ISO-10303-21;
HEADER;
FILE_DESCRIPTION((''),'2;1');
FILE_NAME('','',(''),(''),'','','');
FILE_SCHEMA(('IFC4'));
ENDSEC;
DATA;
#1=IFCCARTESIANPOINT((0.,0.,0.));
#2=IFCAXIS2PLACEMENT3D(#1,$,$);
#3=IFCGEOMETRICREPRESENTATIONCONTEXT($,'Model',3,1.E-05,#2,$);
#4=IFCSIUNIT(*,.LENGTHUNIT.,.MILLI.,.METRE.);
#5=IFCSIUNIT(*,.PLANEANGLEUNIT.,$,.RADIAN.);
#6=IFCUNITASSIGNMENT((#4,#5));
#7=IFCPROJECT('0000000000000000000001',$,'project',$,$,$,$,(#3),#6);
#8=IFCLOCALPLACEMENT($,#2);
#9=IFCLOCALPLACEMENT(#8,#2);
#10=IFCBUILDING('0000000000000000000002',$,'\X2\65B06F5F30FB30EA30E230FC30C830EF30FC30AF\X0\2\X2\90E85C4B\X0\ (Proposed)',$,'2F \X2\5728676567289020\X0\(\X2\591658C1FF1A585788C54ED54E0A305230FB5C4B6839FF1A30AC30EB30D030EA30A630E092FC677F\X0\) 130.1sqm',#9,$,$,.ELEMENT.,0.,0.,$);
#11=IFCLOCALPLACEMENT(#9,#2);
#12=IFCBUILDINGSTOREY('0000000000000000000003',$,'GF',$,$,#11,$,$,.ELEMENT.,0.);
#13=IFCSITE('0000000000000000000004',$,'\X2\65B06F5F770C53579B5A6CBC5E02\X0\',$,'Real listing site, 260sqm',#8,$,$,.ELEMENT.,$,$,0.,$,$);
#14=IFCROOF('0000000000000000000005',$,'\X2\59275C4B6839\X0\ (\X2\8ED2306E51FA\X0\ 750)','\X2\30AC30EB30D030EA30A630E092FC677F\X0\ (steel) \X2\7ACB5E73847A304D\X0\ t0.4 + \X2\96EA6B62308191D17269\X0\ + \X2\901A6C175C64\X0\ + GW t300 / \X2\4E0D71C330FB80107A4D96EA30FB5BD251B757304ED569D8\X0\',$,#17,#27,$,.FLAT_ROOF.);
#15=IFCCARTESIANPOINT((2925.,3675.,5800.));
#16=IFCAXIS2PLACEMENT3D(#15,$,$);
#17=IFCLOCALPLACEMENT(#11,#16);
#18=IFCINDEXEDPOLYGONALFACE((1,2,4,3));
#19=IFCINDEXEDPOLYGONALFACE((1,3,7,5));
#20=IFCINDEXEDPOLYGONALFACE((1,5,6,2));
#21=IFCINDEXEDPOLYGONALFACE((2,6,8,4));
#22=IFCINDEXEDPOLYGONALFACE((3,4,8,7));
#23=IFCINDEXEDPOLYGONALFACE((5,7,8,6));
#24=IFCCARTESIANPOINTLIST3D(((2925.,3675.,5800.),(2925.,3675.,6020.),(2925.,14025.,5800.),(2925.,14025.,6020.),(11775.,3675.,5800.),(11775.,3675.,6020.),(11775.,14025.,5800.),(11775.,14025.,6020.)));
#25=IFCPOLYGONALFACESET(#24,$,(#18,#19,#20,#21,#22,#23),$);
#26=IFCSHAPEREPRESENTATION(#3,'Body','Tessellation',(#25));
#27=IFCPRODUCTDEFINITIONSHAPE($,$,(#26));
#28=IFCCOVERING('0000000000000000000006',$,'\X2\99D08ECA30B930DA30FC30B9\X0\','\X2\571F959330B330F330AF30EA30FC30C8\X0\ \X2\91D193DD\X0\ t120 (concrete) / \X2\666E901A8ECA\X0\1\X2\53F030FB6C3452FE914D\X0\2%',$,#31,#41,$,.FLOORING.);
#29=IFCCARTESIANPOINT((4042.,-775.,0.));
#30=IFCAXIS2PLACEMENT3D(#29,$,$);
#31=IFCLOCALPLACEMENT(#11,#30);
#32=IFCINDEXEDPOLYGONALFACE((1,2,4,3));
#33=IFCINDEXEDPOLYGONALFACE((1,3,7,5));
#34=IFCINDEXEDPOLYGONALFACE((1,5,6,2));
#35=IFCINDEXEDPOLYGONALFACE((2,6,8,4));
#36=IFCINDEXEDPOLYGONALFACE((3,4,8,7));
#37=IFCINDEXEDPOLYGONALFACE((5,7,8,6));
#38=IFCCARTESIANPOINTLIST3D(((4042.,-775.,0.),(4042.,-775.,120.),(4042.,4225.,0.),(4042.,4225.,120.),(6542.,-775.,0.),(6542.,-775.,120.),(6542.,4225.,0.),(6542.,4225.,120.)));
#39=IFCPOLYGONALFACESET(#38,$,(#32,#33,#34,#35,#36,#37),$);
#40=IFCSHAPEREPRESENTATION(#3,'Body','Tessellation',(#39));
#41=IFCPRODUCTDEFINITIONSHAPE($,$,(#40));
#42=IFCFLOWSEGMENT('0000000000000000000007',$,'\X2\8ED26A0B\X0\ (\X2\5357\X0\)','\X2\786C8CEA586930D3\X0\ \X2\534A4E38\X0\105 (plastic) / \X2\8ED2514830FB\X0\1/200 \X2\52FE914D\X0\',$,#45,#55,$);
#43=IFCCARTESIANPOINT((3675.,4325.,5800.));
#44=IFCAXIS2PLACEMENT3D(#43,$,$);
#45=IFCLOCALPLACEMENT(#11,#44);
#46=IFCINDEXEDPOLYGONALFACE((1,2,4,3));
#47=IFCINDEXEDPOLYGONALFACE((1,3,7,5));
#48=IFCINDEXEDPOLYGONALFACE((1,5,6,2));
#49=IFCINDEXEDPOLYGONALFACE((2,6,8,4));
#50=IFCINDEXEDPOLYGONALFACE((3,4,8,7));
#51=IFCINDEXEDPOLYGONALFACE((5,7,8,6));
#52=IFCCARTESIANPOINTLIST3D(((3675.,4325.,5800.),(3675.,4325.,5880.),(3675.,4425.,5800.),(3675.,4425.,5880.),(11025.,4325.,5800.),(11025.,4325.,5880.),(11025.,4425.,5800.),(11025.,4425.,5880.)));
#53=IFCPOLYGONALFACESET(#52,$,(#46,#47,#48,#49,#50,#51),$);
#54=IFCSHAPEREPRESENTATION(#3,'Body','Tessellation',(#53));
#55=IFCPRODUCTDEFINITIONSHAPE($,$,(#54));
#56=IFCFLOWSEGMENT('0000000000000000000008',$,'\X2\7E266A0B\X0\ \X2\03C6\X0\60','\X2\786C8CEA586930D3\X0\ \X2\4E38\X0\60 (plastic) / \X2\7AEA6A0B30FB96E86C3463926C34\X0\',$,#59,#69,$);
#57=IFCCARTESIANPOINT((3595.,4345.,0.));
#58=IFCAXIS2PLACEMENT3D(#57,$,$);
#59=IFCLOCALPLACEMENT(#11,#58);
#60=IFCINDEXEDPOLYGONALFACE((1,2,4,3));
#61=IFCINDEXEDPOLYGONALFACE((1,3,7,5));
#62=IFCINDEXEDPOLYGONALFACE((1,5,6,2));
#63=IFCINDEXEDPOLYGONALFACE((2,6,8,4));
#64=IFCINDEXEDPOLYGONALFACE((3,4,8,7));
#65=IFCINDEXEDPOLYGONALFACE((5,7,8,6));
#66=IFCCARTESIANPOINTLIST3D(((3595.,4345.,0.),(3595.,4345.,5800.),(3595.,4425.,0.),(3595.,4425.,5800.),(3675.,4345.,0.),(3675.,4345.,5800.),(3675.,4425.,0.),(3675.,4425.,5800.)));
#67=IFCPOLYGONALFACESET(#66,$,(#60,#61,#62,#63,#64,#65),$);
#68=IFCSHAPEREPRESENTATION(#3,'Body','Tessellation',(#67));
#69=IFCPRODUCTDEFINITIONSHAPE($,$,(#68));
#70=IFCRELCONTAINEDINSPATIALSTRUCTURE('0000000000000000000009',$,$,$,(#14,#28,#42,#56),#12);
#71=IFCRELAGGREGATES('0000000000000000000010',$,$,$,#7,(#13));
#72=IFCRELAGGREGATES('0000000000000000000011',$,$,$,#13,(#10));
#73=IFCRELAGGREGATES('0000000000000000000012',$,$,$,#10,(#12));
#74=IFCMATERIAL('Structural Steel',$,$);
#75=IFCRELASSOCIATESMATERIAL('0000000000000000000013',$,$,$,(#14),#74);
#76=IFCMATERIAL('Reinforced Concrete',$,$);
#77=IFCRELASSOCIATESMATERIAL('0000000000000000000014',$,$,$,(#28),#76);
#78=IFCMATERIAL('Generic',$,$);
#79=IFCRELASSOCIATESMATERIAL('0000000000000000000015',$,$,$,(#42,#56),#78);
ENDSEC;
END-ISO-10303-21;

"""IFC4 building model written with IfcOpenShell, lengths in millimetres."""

from ifc_helpers import new_model, si_unit, frame, frame_2d, origin, place, context, project, spatial, rectangle, extrude, material, element, save


model = new_model("IFC4")

# Units and contexts
model_context = context("Model", 3, precision=1e-05, world=origin())
ifc_project = project(units=[si_unit("LENGTHUNIT", "METRE", prefix="MILLI"), si_unit("PLANEANGLEUNIT", "RADIAN")], contexts=[model_context])

# Site, building, storey
site_placement = place(None, origin())
site = spatial("IfcSite", under=ifc_project, at=site_placement, Name="新潟県南魚沼市", ObjectType="Real listing site, 260sqm", CompositionType="ELEMENT", RefElevation=0.0)
building_placement = place(site_placement, origin())
building = spatial("IfcBuilding", under=site, at=building_placement, Name="新潟・リモートワーク2部屋 (Proposed)", ObjectType="2F 在来木造(外壁：塗装仕上げ・屋根：ガルバリウム鋼板) 130.1sqm", CompositionType="ELEMENT", ElevationOfRefHeight=0.0, ElevationOfTerrain=0.0)
storey_placement = place(building_placement, origin())
storey = spatial("IfcBuildingStorey", under=building, at=storey_placement, Name="GF", CompositionType="ELEMENT", Elevation=0.0)

# Shared definitions
ifc_material_1 = material(Name="Reinforced Concrete")

# Roof
ifc_material_2 = material(Name="Structural Steel")
roof_placement = place(storey_placement, frame((2925.0, 3675.0, 5800.0)))
element("IfcRoof", 1, at=roof_placement, inside=storey, material=ifc_material_2, Name="大屋根 (軒の出 750)", Description="ガルバリウム鋼板 (steel) 立平葺き t0.4 + 雪止め金物 + 通気層 + GW t300 / 不燃・耐積雪・寒冷地仕様", PredefinedType="FLAT_ROOF", context=model_context, shape_type="SweptSolid", body=[
    extrude(rectangle(XDim=8850.0, YDim=10350.0, at=frame_2d((4425.0, 5175.0))), frame((2925.0, 3675.0, 5800.0)), (0.0, 0.0, 1.0), 220.0),
])

# Covering
covering_placement = place(storey_placement, frame((4042.0, -775.0, 0.0)))
element("IfcCovering", 2, at=covering_placement, inside=storey, material=ifc_material_1, Name="駐車スペース", Description="土間コンクリート 金鏝 t120 (concrete) / 普通車1台・水勾配2%", PredefinedType="FLOORING", context=model_context, shape_type="SweptSolid", body=[
    extrude(rectangle(XDim=2500.0, YDim=5000.0, at=frame_2d((1250.0, 2500.0))), frame((4042.0, -775.0, 0.0)), (0.0, 0.0, 1.0), 120.0),
])

# Flow segments
ifc_material_3 = material(Name="Generic")
flow_segment_1_placement = place(storey_placement, frame((3675.0, 4325.0, 5800.0)))
element("IfcFlowSegment", 3, at=flow_segment_1_placement, inside=storey, material=ifc_material_3, Name="軒樋 (南)", Description="硬質塩ビ 半丸105 (plastic) / 軒先・1/200 勾配", context=model_context, shape_type="SweptSolid", body=[
    extrude(rectangle(XDim=7350.0, YDim=100.0, at=frame_2d((3675.0, 50.0))), frame((3675.0, 4325.0, 5800.0)), (0.0, 0.0, 1.0), 80.0),
])
flow_segment_2_placement = place(storey_placement, frame((3595.0, 4345.0, 0.0)))
element("IfcFlowSegment", 4, at=flow_segment_2_placement, inside=storey, material=ifc_material_3, Name="縦樋 φ60", Description="硬質塩ビ 丸60 (plastic) / 竪樋・雨水排水", context=model_context, shape_type="SweptSolid", body=[
    extrude(rectangle(XDim=80.0, YDim=80.0, at=frame_2d((40.0, 40.0))), frame((3595.0, 4345.0, 0.0)), (0.0, 0.0, 1.0), 5800.0),
])

save(model, "model.ifc")
